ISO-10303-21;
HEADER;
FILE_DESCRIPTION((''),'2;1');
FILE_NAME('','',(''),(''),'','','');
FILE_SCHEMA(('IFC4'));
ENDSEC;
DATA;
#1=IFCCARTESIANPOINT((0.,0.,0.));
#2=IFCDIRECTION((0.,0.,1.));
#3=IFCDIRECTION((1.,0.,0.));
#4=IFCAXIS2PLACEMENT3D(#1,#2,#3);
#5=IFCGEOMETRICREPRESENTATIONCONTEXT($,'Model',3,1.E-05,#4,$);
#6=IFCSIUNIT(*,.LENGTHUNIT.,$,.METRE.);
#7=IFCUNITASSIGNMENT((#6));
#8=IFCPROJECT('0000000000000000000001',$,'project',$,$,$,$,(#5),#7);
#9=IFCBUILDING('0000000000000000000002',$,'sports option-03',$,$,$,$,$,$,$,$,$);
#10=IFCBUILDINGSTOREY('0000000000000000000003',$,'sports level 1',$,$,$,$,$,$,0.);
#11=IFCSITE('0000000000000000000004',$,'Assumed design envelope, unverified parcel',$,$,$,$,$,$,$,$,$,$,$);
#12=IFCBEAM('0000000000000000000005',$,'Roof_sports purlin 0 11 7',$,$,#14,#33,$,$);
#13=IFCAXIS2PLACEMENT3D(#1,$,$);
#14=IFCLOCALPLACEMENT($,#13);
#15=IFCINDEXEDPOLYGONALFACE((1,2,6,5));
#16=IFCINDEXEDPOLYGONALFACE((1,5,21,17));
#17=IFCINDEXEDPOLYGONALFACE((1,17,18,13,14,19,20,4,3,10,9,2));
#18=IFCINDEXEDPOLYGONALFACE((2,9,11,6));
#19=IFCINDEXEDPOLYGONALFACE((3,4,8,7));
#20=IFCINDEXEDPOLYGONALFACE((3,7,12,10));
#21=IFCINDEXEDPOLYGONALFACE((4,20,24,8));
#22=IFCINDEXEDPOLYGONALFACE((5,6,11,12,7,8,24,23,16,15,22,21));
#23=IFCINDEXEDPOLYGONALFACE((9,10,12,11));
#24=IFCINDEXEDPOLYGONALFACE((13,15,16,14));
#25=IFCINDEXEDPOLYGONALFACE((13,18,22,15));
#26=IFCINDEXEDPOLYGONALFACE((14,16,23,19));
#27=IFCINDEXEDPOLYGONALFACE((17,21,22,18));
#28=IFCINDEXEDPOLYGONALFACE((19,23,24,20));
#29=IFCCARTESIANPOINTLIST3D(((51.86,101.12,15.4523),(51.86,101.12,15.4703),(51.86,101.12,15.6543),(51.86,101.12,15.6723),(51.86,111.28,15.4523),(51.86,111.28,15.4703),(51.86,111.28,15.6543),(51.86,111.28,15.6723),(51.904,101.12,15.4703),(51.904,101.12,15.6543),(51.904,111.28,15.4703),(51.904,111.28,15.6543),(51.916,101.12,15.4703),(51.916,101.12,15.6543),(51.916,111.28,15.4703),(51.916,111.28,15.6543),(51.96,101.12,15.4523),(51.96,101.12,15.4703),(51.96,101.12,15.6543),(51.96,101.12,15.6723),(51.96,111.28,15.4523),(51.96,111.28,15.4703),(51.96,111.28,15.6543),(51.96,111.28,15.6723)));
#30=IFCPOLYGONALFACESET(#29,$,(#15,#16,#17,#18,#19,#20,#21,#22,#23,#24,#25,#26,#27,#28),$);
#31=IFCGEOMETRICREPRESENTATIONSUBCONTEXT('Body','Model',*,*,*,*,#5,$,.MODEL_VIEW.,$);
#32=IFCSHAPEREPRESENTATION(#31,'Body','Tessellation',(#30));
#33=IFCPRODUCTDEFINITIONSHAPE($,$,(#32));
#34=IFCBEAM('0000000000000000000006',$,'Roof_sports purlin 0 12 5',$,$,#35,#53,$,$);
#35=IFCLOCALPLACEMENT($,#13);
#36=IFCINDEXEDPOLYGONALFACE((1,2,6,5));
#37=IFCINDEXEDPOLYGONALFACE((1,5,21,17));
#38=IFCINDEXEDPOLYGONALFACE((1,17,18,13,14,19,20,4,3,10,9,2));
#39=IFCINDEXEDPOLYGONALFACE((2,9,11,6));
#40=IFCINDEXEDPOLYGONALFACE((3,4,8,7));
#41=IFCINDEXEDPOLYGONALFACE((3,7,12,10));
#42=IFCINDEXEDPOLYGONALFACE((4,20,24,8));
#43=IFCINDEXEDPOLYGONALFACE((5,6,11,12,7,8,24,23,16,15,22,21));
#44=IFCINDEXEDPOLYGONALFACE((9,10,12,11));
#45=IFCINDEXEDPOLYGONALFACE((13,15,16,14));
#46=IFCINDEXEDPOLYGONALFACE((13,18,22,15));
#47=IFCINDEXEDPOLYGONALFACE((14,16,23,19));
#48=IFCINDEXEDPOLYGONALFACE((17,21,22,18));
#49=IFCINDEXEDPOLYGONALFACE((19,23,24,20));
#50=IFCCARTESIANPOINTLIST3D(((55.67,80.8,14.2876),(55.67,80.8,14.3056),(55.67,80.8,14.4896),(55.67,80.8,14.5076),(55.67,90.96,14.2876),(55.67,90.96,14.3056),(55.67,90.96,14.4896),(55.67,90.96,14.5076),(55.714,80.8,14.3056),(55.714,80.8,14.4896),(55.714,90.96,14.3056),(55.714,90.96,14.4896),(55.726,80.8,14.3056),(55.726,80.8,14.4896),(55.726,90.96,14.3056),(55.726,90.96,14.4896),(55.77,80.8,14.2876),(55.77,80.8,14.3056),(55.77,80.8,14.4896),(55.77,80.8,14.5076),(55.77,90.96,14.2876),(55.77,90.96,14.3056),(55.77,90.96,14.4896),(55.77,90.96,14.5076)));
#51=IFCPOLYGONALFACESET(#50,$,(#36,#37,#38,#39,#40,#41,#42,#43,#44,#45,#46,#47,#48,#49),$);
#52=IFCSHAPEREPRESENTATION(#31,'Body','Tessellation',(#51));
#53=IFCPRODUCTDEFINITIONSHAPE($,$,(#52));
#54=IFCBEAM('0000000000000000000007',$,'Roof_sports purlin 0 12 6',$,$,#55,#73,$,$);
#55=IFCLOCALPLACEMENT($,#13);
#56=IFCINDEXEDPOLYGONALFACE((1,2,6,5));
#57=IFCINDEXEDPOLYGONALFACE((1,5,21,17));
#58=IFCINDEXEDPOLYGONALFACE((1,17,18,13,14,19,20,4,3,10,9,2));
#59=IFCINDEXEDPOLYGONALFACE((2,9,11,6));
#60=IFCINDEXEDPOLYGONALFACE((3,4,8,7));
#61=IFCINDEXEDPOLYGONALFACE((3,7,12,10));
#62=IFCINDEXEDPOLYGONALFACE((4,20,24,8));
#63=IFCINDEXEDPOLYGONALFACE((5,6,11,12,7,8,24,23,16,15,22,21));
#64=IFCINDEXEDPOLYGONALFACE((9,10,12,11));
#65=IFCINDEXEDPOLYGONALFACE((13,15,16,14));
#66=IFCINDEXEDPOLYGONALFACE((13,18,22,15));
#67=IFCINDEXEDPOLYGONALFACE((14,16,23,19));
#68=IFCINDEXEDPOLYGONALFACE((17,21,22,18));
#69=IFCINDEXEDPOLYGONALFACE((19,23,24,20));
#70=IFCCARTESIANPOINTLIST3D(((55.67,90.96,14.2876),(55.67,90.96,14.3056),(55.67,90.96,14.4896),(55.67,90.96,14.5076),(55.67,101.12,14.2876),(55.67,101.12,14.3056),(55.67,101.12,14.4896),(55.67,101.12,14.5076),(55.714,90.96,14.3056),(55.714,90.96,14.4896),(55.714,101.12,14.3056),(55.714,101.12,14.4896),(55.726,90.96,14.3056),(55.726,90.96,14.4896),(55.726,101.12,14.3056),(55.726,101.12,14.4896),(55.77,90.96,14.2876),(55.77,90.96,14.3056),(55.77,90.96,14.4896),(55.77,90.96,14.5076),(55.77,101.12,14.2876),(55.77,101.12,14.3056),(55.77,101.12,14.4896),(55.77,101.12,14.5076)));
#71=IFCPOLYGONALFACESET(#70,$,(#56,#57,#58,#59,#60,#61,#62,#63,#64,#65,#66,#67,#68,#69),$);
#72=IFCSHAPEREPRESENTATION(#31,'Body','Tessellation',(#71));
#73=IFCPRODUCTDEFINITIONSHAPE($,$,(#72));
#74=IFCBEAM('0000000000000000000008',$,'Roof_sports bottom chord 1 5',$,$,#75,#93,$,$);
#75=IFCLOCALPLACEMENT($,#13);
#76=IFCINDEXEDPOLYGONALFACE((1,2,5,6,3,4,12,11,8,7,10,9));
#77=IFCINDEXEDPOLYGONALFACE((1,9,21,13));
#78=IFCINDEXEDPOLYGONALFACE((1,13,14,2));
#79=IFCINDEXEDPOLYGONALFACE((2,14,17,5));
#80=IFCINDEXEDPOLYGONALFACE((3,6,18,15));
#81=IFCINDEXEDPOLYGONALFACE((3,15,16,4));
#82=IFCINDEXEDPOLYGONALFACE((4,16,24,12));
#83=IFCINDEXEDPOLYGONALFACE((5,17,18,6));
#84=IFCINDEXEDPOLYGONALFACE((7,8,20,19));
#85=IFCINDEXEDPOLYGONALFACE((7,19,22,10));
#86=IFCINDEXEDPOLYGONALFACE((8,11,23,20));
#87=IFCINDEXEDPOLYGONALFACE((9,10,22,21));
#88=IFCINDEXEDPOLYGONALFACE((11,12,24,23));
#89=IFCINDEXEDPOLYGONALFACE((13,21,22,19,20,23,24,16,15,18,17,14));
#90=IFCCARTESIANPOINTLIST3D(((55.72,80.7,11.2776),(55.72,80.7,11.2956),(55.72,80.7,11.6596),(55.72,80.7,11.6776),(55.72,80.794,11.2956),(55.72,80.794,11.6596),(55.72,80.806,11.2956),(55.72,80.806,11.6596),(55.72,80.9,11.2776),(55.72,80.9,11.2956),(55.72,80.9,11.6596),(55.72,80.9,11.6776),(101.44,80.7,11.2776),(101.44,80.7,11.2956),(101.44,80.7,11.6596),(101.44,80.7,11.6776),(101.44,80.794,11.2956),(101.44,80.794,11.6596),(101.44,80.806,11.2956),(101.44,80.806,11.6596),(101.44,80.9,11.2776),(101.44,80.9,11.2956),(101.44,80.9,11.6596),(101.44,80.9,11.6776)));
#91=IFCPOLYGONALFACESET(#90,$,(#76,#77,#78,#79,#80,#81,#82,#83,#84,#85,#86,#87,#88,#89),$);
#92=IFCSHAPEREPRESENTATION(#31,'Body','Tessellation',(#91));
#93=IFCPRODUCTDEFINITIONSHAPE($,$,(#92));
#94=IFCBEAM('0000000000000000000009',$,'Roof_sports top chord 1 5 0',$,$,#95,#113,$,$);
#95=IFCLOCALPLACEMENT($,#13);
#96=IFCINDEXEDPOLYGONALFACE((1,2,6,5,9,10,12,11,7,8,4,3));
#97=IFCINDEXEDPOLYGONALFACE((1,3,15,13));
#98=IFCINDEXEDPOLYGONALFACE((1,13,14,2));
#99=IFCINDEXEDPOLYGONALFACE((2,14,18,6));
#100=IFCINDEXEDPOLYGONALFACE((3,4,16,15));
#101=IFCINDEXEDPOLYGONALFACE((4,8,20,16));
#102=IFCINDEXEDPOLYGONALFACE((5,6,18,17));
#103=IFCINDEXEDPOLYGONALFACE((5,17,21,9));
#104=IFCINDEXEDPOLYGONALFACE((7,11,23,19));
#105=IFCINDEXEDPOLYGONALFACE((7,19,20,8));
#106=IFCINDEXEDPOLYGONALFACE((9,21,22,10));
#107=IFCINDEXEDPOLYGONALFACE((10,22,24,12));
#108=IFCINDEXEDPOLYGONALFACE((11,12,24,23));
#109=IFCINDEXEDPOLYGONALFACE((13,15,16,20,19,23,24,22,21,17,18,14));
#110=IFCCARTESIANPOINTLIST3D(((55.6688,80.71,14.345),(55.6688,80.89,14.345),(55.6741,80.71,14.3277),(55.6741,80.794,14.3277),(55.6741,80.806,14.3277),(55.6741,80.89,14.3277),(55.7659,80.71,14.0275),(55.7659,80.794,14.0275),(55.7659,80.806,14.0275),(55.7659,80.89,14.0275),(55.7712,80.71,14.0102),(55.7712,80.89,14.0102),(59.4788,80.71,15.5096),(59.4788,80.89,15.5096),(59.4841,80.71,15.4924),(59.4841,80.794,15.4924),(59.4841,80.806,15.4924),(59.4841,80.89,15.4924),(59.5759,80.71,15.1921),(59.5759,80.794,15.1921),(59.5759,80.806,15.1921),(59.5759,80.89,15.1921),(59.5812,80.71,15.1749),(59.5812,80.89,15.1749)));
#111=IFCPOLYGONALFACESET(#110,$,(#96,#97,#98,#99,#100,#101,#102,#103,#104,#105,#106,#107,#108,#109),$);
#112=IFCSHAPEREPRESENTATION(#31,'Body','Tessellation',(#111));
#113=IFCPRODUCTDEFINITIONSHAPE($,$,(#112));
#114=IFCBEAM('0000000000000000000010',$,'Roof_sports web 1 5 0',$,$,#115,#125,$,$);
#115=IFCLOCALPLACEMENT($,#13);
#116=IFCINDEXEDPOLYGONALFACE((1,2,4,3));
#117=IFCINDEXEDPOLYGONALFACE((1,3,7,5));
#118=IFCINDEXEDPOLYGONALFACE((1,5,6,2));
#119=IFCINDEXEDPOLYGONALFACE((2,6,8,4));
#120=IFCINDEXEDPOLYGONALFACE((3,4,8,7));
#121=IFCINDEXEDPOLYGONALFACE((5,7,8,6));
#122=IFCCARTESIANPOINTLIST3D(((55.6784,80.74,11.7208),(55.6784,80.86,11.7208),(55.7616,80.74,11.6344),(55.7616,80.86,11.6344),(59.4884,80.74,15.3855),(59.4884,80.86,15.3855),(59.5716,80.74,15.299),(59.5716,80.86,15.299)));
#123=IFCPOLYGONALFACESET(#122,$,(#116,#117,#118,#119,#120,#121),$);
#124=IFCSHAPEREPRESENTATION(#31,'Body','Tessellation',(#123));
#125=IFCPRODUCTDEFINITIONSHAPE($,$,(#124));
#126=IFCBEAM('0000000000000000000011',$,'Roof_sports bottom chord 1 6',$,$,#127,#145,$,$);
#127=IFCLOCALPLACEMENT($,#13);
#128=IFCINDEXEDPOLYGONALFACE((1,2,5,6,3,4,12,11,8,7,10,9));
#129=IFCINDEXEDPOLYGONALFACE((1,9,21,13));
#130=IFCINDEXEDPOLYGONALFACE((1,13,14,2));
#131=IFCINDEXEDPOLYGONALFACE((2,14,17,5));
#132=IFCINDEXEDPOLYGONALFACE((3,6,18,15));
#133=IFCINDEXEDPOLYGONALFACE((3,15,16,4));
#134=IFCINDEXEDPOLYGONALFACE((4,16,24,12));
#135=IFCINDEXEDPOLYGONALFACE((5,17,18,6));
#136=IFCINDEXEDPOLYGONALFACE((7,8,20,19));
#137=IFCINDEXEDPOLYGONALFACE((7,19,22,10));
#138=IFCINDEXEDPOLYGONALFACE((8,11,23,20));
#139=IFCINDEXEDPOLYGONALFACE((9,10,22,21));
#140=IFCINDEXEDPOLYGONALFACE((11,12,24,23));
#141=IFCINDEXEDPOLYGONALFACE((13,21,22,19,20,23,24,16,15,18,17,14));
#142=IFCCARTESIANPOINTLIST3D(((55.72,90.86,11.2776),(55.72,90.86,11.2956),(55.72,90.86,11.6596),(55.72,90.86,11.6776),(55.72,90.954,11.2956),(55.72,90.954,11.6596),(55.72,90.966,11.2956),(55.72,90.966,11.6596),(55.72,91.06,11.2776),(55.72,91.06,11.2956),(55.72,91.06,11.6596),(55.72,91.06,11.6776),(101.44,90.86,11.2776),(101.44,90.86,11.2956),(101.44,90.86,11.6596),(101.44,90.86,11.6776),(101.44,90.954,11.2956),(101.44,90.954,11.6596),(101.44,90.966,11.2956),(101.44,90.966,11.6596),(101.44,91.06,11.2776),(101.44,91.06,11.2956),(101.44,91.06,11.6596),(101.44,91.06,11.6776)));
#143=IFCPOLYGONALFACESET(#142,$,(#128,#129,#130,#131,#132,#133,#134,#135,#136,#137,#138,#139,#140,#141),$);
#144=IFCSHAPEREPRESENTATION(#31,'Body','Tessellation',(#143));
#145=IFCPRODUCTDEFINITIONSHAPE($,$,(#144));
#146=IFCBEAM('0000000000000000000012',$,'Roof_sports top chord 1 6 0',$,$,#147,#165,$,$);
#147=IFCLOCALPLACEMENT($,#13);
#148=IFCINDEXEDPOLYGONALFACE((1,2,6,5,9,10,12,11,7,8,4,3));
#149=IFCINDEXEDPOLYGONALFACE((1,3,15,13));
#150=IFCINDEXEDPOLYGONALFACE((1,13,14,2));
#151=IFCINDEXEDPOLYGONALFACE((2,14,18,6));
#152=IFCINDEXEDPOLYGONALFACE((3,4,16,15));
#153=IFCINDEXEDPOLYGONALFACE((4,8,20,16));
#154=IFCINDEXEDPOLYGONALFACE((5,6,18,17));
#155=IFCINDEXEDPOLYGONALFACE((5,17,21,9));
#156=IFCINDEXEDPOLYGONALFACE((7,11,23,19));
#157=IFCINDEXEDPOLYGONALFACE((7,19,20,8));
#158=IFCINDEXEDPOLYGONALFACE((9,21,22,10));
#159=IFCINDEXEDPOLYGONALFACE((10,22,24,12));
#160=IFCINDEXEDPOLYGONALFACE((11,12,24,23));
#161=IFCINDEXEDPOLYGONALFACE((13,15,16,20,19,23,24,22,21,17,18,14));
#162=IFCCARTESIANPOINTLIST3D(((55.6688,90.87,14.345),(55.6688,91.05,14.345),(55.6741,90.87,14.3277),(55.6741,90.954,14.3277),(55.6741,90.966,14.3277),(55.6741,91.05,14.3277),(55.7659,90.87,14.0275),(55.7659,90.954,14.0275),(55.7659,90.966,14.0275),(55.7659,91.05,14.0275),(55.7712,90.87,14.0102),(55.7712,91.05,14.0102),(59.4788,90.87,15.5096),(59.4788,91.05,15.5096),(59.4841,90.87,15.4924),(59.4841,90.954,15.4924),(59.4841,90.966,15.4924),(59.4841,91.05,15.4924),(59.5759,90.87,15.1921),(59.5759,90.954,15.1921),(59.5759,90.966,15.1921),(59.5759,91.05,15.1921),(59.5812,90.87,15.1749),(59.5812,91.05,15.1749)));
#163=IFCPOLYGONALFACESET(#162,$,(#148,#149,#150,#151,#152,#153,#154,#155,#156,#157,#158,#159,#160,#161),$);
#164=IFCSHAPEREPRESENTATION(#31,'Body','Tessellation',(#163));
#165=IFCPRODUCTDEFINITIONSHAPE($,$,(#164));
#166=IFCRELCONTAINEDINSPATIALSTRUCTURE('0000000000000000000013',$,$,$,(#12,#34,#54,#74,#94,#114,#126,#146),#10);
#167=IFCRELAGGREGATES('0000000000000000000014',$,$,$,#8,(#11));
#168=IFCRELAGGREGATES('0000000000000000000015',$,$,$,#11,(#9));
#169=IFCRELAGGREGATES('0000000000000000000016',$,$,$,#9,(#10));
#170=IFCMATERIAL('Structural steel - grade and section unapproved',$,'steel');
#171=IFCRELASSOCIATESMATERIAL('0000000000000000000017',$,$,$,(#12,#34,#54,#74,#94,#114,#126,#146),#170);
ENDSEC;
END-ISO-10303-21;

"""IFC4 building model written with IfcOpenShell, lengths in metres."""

from ifc_helpers import new_model, si_unit, frame, origin_with_axes, place, context, subcontext, project, spatial, rectangle, i_section, extrude, material, element, save


model = new_model("IFC4")

# Units and contexts
model_context = context("Model", 3, precision=1e-05, world=origin_with_axes())
body_context = subcontext(model_context, "Body", "Model", "MODEL_VIEW")
ifc_project = project(units=[si_unit("LENGTHUNIT", "METRE")], contexts=[model_context])

# Site, building, storey
site = spatial("IfcSite", under=ifc_project, Name="Assumed design envelope, unverified parcel")
building = spatial("IfcBuilding", under=site, Name="sports option-03")
storey = spatial("IfcBuildingStorey", under=building, Name="sports level 1", Elevation=0.0)

# Shared definitions
ifc_material = material(Name="Structural steel - grade and section unapproved", Category="steel")

# Beams
for number, where, z_axis, x_axis, name in (
    (1, (51.91, 101.12, 15.5623), (0.0, 1.0, 0.0), (-1.0, 0.0, 0.0), "Roof_sports purlin 0 11 7"),
    (2, (55.72, 80.8, 14.3976), (0.0, 1.0, 0.0), (-1.0, 0.0, 0.0), "Roof_sports purlin 0 12 5"),
):
    element("IfcBeam", number, at=place(None, frame(where, z_axis=z_axis, x_axis=x_axis)), inside=storey, material=ifc_material, Name=name, context=body_context, shape_type="SweptSolid", body=[
        extrude(i_section(OverallWidth=0.1, OverallDepth=0.22, WebThickness=0.012, FlangeThickness=0.018, FilletRadius=0.0), origin_with_axes(), (0.0, 0.0, 1.0), 10.16),
    ])
beam_1_placement = place(None, frame((55.72, 90.96, 14.3976), z_axis=(0.0, 1.0, 0.0), x_axis=(-1.0, 0.0, 0.0)))
element("IfcBeam", 3, at=beam_1_placement, inside=storey, material=ifc_material, Name="Roof_sports purlin 0 12 6", context=body_context, shape_type="SweptSolid", body=[
    extrude(i_section(OverallWidth=0.1, OverallDepth=0.22, WebThickness=0.012, FlangeThickness=0.018, FilletRadius=0.0), origin_with_axes(), (0.0, 0.0, 1.0), 10.16),
])
beam_2_placement = place(None, frame((55.72, 80.8, 11.4776), z_axis=(1.0, 0.0, 0.0), x_axis=(0.0, 1.0, 0.0)))
element("IfcBeam", 4, at=beam_2_placement, inside=storey, material=ifc_material, Name="Roof_sports bottom chord 1 5", context=body_context, shape_type="SweptSolid", body=[
    extrude(i_section(OverallWidth=0.2, OverallDepth=0.4, WebThickness=0.012, FlangeThickness=0.018, FilletRadius=0.0), origin_with_axes(), (0.0, 0.0, 1.0), 45.72),
])
beam_3_placement = place(None, frame((55.72, 80.8, 14.1776), z_axis=(0.956315, 0.0, 0.292338), x_axis=(0.0, 1.0, 0.0)))
element("IfcBeam", 5, at=beam_3_placement, inside=storey, material=ifc_material, Name="Roof_sports top chord 1 5 0", context=body_context, shape_type="SweptSolid", body=[
    extrude(i_section(OverallWidth=0.18, OverallDepth=0.35, WebThickness=0.012, FlangeThickness=0.018, FilletRadius=0.0), origin_with_axes(), (0.0, 0.0, 1.0), 3.984),
])
beam_4_placement = place(None, frame((55.72, 80.8, 11.6776), z_axis=(0.720717, 0.0, 0.693229), x_axis=(0.0, 1.0, 0.0)))
element("IfcBeam", 6, at=beam_4_placement, inside=storey, material=ifc_material, Name="Roof_sports web 1 5 0", context=body_context, shape_type="SweptSolid", body=[
    extrude(rectangle(XDim=0.12, YDim=0.12), origin_with_axes(), (0.0, 0.0, 1.0), 5.2864),
])
beam_5_placement = place(None, frame((55.72, 90.96, 11.4776), z_axis=(1.0, 0.0, 0.0), x_axis=(0.0, 1.0, 0.0)))
element("IfcBeam", 7, at=beam_5_placement, inside=storey, material=ifc_material, Name="Roof_sports bottom chord 1 6", context=body_context, shape_type="SweptSolid", body=[
    extrude(i_section(OverallWidth=0.2, OverallDepth=0.4, WebThickness=0.012, FlangeThickness=0.018, FilletRadius=0.0), origin_with_axes(), (0.0, 0.0, 1.0), 45.72),
])
beam_6_placement = place(None, frame((55.72, 90.96, 14.1776), z_axis=(0.956315, 0.0, 0.292338), x_axis=(0.0, 1.0, 0.0)))
element("IfcBeam", 8, at=beam_6_placement, inside=storey, material=ifc_material, Name="Roof_sports top chord 1 6 0", context=body_context, shape_type="SweptSolid", body=[
    extrude(i_section(OverallWidth=0.18, OverallDepth=0.35, WebThickness=0.012, FlangeThickness=0.018, FilletRadius=0.0), origin_with_axes(), (0.0, 0.0, 1.0), 3.984),
])

save(model, "model.ifc")
